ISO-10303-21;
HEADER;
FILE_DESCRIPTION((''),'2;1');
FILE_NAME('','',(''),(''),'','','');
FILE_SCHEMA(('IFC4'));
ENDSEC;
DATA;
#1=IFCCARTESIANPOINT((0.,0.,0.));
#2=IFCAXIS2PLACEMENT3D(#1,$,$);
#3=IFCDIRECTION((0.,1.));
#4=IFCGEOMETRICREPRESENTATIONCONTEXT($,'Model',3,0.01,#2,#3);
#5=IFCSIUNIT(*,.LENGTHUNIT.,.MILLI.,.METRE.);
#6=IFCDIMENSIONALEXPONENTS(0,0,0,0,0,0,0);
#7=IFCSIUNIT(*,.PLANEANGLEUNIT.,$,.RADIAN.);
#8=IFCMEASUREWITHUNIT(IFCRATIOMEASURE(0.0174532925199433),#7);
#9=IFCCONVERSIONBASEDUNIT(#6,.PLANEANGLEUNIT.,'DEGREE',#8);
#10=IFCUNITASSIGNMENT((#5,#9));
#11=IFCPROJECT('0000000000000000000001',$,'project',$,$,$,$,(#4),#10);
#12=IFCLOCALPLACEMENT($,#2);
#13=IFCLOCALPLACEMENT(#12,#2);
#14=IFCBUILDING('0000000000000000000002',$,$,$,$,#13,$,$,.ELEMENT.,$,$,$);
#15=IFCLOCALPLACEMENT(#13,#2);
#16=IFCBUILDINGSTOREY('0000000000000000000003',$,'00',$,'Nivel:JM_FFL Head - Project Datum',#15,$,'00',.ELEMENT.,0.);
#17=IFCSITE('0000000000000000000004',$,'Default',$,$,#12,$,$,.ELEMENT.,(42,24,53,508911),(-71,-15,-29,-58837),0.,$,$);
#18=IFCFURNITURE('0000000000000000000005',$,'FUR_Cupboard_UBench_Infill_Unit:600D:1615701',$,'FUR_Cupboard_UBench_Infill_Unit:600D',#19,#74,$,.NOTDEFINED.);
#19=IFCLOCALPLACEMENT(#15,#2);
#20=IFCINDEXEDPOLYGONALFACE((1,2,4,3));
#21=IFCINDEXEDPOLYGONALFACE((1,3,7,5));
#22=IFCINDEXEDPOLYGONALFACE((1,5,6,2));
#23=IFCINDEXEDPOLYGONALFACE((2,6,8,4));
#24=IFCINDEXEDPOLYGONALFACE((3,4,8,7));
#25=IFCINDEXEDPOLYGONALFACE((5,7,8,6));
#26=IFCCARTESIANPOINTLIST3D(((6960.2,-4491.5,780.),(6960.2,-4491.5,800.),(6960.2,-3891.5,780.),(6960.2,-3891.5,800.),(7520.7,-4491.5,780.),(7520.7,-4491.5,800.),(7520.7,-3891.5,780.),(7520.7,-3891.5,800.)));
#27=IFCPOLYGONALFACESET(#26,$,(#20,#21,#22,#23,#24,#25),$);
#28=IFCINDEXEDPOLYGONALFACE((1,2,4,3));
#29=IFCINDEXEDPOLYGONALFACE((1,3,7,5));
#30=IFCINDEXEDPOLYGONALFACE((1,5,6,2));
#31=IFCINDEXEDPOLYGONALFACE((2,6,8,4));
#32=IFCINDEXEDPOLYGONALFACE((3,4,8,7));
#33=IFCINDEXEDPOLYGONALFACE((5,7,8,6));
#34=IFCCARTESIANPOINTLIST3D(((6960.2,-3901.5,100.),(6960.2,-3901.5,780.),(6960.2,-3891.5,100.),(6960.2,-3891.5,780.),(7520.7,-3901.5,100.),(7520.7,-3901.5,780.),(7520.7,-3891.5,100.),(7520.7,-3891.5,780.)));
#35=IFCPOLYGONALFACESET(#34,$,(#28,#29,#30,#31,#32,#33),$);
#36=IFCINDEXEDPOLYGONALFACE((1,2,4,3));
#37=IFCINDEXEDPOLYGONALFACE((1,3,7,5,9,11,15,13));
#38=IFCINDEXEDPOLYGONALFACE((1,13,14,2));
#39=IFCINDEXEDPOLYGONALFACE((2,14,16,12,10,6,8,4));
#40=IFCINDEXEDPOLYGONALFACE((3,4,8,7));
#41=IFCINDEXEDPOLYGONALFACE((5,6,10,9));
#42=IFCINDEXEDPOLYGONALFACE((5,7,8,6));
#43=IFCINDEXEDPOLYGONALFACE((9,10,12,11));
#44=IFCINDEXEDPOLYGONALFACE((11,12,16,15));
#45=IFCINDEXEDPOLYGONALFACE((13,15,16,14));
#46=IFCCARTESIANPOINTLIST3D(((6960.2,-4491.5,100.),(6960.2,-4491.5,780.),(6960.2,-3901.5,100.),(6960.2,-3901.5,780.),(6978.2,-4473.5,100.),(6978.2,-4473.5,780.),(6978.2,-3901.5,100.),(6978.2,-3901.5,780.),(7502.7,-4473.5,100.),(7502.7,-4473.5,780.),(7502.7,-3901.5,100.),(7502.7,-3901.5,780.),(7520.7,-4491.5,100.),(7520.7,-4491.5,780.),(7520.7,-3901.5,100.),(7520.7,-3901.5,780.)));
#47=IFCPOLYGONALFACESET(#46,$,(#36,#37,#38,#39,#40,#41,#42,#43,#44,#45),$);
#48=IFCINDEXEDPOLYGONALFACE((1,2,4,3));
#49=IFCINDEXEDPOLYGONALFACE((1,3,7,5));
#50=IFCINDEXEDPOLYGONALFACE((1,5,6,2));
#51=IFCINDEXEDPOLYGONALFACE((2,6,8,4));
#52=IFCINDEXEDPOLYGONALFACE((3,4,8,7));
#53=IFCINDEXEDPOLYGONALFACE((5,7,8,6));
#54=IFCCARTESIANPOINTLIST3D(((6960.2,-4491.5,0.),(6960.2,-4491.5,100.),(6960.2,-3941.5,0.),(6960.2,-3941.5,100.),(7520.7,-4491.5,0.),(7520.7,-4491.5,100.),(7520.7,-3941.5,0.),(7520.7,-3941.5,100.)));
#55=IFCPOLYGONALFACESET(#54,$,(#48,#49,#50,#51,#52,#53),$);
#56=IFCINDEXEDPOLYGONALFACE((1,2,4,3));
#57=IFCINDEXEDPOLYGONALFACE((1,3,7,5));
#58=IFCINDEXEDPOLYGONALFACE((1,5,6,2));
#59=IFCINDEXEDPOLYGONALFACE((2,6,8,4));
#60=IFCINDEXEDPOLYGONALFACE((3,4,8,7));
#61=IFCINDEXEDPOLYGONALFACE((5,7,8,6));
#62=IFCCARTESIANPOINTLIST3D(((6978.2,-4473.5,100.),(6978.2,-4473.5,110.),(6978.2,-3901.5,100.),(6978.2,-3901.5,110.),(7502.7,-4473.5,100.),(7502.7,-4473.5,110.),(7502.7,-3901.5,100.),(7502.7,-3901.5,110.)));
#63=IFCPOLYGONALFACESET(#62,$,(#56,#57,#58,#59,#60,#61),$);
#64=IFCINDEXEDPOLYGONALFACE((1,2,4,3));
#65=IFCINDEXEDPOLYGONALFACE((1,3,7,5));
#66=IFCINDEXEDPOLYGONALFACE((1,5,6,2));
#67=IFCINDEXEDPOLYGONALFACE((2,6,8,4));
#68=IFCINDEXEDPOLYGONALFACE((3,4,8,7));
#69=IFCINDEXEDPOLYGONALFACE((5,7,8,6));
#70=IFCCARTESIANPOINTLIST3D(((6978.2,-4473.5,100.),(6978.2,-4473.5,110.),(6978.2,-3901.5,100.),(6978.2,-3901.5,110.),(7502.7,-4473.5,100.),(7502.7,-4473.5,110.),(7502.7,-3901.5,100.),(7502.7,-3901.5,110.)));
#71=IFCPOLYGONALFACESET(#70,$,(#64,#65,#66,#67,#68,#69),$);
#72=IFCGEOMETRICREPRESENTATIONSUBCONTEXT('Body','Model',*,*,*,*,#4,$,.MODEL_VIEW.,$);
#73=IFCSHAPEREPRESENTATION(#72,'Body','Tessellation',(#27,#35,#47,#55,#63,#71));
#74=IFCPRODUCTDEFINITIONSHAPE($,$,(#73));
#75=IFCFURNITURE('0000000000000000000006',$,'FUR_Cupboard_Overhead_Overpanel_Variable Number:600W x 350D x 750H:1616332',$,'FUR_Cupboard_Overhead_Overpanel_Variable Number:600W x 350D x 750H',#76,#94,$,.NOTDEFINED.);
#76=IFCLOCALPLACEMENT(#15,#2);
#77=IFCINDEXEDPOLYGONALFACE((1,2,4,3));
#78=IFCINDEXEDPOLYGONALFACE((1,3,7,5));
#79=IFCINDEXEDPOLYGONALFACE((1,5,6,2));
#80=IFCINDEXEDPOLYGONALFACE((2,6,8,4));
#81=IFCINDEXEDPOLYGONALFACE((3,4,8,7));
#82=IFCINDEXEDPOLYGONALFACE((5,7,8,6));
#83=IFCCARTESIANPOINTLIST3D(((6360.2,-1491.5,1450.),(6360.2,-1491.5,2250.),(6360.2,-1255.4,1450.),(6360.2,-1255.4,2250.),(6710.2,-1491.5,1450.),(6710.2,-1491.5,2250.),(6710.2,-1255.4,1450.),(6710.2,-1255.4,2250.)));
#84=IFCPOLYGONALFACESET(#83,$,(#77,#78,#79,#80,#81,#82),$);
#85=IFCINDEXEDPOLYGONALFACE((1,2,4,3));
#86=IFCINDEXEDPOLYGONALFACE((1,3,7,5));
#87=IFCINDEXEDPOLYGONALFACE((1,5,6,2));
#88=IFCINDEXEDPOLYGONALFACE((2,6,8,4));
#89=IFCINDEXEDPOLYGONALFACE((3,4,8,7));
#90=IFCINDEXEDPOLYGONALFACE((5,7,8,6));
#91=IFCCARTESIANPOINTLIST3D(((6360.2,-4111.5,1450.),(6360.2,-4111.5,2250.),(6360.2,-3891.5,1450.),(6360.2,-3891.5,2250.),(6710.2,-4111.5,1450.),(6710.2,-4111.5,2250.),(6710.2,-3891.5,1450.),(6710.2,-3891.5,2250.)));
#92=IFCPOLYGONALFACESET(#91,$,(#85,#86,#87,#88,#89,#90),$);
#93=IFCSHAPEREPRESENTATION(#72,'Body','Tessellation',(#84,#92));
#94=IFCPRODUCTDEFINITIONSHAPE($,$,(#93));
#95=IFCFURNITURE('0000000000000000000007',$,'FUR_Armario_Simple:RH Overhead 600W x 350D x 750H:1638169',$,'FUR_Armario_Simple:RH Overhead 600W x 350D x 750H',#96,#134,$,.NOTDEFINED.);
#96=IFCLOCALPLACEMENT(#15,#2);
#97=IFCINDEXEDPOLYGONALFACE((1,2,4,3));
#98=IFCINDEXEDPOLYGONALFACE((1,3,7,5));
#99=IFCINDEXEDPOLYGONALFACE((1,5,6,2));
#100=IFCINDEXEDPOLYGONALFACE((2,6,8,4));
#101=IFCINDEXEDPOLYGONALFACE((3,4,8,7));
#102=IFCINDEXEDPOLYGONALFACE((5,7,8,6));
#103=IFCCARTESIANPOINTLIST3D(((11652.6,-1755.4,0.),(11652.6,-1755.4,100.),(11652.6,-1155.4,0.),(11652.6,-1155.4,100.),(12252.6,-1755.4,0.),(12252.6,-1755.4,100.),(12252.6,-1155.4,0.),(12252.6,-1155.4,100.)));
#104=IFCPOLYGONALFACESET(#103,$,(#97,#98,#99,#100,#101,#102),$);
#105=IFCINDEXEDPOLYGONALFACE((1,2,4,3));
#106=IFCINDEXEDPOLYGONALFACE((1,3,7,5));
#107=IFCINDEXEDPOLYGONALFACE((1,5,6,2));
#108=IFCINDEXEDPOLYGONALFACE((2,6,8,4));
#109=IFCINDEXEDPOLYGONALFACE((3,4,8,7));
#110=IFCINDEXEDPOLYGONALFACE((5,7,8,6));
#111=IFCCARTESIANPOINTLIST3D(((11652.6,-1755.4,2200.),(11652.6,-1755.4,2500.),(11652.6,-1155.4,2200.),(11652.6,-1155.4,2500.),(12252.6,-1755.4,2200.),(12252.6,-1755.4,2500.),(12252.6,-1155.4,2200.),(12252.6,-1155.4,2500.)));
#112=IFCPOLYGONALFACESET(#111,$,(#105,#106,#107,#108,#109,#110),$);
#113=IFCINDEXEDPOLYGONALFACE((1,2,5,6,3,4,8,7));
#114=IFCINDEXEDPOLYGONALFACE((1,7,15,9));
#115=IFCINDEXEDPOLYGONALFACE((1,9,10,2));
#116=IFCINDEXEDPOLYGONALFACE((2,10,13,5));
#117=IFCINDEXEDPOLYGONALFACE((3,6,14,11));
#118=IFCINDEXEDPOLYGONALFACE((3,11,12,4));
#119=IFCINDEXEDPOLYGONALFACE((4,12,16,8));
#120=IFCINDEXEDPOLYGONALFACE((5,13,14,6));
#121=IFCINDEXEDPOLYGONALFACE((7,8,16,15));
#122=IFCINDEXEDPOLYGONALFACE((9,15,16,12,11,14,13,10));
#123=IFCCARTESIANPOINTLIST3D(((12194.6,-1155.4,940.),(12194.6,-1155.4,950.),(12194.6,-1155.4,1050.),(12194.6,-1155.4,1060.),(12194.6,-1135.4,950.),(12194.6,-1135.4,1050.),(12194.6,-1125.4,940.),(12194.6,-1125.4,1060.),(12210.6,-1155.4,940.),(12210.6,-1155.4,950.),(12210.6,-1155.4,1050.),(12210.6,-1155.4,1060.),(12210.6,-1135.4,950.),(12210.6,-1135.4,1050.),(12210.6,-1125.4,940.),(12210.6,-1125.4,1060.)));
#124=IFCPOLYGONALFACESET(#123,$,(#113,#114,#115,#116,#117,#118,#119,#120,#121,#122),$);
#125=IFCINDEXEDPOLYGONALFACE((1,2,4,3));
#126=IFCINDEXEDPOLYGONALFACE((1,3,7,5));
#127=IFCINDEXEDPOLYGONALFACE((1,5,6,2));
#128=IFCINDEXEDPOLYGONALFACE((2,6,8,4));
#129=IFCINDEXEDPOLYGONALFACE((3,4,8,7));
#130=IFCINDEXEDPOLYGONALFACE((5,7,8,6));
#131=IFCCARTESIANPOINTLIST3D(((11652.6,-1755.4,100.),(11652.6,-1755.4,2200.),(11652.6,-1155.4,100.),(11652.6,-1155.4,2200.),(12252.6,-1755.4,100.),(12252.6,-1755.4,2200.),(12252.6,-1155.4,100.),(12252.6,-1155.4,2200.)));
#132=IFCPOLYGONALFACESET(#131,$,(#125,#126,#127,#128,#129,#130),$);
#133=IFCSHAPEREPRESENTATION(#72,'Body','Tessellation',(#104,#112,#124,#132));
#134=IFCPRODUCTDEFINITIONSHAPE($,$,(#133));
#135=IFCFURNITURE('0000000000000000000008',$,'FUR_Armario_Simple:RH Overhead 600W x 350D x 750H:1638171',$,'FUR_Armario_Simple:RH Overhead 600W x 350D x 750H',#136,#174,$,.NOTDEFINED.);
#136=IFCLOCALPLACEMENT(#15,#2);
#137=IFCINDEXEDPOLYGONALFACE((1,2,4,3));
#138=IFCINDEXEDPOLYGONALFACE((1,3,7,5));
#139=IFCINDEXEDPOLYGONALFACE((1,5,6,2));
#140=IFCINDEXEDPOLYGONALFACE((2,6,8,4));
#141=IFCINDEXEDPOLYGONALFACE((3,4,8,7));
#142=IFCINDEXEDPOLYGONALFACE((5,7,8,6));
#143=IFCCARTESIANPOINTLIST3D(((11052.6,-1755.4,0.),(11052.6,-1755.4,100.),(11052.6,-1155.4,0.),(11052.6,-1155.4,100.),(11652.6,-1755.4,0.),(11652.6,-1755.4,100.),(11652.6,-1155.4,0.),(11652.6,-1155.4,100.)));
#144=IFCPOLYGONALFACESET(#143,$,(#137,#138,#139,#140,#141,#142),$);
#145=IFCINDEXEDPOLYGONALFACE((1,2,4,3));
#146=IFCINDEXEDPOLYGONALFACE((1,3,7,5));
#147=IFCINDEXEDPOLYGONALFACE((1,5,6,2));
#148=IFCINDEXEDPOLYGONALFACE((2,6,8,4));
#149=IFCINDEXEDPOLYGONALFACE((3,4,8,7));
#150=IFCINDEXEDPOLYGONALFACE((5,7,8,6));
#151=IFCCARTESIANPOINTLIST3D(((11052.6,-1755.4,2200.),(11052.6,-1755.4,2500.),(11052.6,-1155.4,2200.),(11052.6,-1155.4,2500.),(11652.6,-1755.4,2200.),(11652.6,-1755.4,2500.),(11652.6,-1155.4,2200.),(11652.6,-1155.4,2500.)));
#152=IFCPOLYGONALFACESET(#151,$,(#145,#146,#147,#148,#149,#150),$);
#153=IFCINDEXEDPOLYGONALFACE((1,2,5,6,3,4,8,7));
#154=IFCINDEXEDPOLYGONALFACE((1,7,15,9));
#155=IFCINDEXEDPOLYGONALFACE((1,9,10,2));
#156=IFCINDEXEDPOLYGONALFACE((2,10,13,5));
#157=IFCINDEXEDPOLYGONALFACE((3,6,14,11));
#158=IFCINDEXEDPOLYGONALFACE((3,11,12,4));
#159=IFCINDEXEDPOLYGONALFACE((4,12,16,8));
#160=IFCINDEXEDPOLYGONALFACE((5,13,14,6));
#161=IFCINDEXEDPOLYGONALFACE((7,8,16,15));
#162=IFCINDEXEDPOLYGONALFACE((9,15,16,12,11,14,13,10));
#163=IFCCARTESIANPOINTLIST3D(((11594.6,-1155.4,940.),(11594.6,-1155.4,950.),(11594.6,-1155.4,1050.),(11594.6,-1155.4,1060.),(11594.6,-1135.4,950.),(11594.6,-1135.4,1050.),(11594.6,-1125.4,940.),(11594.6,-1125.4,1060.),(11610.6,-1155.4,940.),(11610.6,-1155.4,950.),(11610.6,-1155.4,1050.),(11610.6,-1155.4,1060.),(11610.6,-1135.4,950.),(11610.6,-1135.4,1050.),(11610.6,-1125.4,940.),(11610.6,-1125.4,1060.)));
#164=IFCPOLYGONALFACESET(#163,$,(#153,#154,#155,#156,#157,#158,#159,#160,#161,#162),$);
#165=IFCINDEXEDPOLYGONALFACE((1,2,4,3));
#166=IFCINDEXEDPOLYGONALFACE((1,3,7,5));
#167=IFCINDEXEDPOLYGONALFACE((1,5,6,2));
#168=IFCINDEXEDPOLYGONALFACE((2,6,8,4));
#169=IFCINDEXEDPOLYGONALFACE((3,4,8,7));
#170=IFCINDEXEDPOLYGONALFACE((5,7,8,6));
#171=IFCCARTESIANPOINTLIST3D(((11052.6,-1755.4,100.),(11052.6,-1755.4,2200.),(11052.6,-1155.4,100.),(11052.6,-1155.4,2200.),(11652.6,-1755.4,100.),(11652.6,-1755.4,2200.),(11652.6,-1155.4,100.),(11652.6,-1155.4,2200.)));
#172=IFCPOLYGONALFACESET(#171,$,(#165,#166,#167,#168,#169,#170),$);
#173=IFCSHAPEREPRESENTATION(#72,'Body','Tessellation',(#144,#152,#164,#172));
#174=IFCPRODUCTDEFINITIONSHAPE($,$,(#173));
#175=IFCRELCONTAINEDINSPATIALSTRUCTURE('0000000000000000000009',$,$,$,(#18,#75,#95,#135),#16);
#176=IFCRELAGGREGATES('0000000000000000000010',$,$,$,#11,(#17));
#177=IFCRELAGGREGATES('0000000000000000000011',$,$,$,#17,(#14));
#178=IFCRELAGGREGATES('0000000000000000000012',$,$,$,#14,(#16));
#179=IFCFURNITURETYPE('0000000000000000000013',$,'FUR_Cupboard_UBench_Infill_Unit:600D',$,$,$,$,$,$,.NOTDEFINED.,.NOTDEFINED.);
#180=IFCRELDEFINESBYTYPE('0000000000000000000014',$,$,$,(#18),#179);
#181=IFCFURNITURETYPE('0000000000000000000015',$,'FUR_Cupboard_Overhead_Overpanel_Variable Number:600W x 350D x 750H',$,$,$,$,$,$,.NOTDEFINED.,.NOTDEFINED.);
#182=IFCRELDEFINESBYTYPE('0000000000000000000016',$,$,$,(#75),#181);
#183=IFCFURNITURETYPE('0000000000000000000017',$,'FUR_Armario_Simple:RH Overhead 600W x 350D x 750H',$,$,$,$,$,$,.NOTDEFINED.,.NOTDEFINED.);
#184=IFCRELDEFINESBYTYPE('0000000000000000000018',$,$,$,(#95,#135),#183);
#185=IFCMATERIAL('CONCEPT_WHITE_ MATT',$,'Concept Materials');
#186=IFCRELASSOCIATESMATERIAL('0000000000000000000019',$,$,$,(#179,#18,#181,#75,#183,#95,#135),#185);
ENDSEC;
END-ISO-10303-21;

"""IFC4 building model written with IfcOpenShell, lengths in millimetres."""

from ifc_helpers import new_model, entity, si_unit, converted_unit, direction, frame, origin, place, context, subcontext, project, spatial, indexed_curve, outline, extrude, source, transform, mapped, material, type_object, type_shapes, element, save


model = new_model("IFC4")

# Units and contexts
model_context = context("Model", 3, precision=0.01, world=origin(), true_north=direction((0.0, 1.0)))
body_context = subcontext(model_context, "Body", "Model", "MODEL_VIEW")
ifc_project = project(units=[si_unit("LENGTHUNIT", "METRE", prefix="MILLI"), converted_unit("PLANEANGLEUNIT", "DEGREE", entity("IfcRatioMeasure", 0.0174532925199433), si_unit("PLANEANGLEUNIT", "RADIAN"), dimensions=[0, 0, 0, 0, 0, 0, 0])], contexts=[model_context])

# Site, building, storey
site_placement = place(None, origin())
site = spatial("IfcSite", under=ifc_project, at=site_placement, Name="Default", CompositionType="ELEMENT", RefLatitude=(42, 24, 53, 508911), RefLongitude=(-71, -15, -29, -58837), RefElevation=0.0)
building_placement = place(site_placement, origin())
building = spatial("IfcBuilding", under=site, at=building_placement, CompositionType="ELEMENT")
storey_placement = place(building_placement, origin())
storey = spatial("IfcBuildingStorey", under=building, at=storey_placement, Name="00", ObjectType="Nivel:JM_FFL Head - Project Datum", LongName="00", CompositionType="ELEMENT", Elevation=0.0)

# Furniture
ifc_material_1 = material(Name="CONCEPT_WHITE_ MATT", Category="Concept Materials")
furniture_type_1 = type_object("IfcFurnitureType", Name="FUR_Cupboard_UBench_Infill_Unit:600D", AssemblyPlace="NOTDEFINED", PredefinedType="NOTDEFINED", material=ifc_material_1)
shared_shape_1 = source(origin(), body_context, "Body", "SweptSolid", [
    extrude(outline(indexed_curve([(-300.0, -280.3), (300.0, -280.3), (300.0, 280.3), (-300.0, 280.3), (-300.0, -280.3)], self_intersect=False)), frame((44.7, 300.0, 780.0), z_axis=(0.0, 0.0, 1.0), x_axis=(0.0, 1.0, 0.0)), (0.0, 0.0, 1.0), 20.0),
    extrude(outline(indexed_curve([(-5.0, -280.3), (5.0, -280.3), (5.0, 280.3), (-5.0, 280.3), (-5.0, -280.3)], self_intersect=False)), frame((44.7, 595.0, 100.0), z_axis=(0.0, 0.0, 1.0), x_axis=(0.0, 1.0, 0.0)), (0.0, 0.0, 1.0), 680.0),
    extrude(outline(indexed_curve([(-299.5, -280.3), (290.5, -280.3), (290.5, -262.3), (-281.5, -262.3), (-281.5, 262.3), (290.5, 262.3), (290.5, 280.3), (-299.5, 280.3), (-299.5, -280.3)], self_intersect=False)), frame((44.7, 299.5, 100.0), z_axis=(0.0, 0.0, 1.0), x_axis=(0.0, 1.0, 0.0)), (0.0, 0.0, 1.0), 680.0),
    extrude(outline(indexed_curve([(-275.0, -280.3), (275.0, -280.3), (275.0, 280.3), (-275.0, 280.3), (-275.0, -280.3)], self_intersect=False)), frame((44.7, 275.0, 0.0), z_axis=(0.0, 0.0, 1.0), x_axis=(0.0, 1.0, 0.0)), (0.0, 0.0, 1.0), 100.0),
    extrude(outline(indexed_curve([(-286.0, -262.3), (286.0, -262.3), (286.0, 262.3), (-286.0, 262.3), (-286.0, -262.3)], self_intersect=False)), frame((44.7, 304.0, 100.0), z_axis=(0.0, 0.0, 1.0), x_axis=(0.0, 1.0, 0.0)), (0.0, 0.0, 1.0), 10.0),
    extrude(outline(indexed_curve([(-286.0, -262.3), (286.0, -262.3), (286.0, 262.3), (-286.0, 262.3), (-286.0, -262.3)], self_intersect=False)), frame((44.7, 304.0, 100.0), z_axis=(0.0, 0.0, 1.0), x_axis=(0.0, 1.0, 0.0)), (0.0, 0.0, 1.0), 10.0),
])
type_shapes(furniture_type_1, [shared_shape_1])
furniture_1_placement = place(storey_placement, frame((7195.7, -4491.5, 0.0)))
element("IfcFurniture", 1, at=furniture_1_placement, inside=storey, type_object=furniture_type_1, material=ifc_material_1, Name="FUR_Cupboard_UBench_Infill_Unit:600D:1615701", ObjectType="FUR_Cupboard_UBench_Infill_Unit:600D", PredefinedType="NOTDEFINED", context=body_context, shape_type="MappedRepresentation", body=[
    mapped(shared_shape_1, transform((0.0, 0.0, 0.0), scale=1.0)),
])
furniture_type_2 = type_object("IfcFurnitureType", Name="FUR_Cupboard_Overhead_Overpanel_Variable Number:600W x 350D x 750H", AssemblyPlace="NOTDEFINED", PredefinedType="NOTDEFINED", material=ifc_material_1)
shared_shape_2 = source(origin(), body_context, "Body", "SweptSolid", [
    extrude(outline(indexed_curve([(-175.0, -118.0), (175.0, -118.0), (175.0, 118.0), (-175.0, 118.0), (-175.0, -118.0)], self_intersect=False)), frame((2518.0, -175.0, 1500.0), z_axis=(0.0, 0.0, 1.0), x_axis=(0.0, -1.0, 0.0)), (0.0, 0.0, 1.0), 800.0),
    extrude(outline(indexed_curve([(-110.0, -175.0), (110.0, -175.0), (110.0, 175.0), (-110.0, 175.0), (-110.0, -175.0)], self_intersect=False)), frame((-110.0, -175.0, 1500.0), z_axis=(0.0, 0.0, 1.0), x_axis=(-1.0, 0.0, 0.0)), (0.0, 0.0, 1.0), 800.0),
])
type_shapes(furniture_type_2, [shared_shape_2])
furniture_2_placement = place(storey_placement, frame((6360.2, -3891.5, -50.0), z_axis=(0.0, 0.0, 1.0), x_axis=(0.0, 1.0, 0.0)))
element("IfcFurniture", 2, at=furniture_2_placement, inside=storey, type_object=furniture_type_2, material=ifc_material_1, Name="FUR_Cupboard_Overhead_Overpanel_Variable Number:600W x 350D x 750H:1616332", ObjectType="FUR_Cupboard_Overhead_Overpanel_Variable Number:600W x 350D x 750H", PredefinedType="NOTDEFINED", context=body_context, shape_type="MappedRepresentation", body=[
    mapped(shared_shape_2, transform((0.0, 0.0, 0.0), scale=1.0)),
])
furniture_type_3 = type_object("IfcFurnitureType", Name="FUR_Armario_Simple:RH Overhead 600W x 350D x 750H", AssemblyPlace="NOTDEFINED", PredefinedType="NOTDEFINED", material=ifc_material_1)
shared_shape_3 = source(origin(), body_context, "Body", "SweptSolid", [
    extrude(outline(indexed_curve([(-300.0, -300.0), (300.0, -300.0), (300.0, 300.0), (-300.0, 300.0), (-300.0, -300.0)], self_intersect=False)), frame((300.0, 300.0, 0.0), z_axis=(0.0, 0.0, 1.0), x_axis=(0.0, 1.0, 0.0)), (0.0, 0.0, 1.0), 100.0),
    extrude(outline(indexed_curve([(-300.0, -300.0), (300.0, -300.0), (300.0, 300.0), (-300.0, 300.0), (-300.0, -300.0)], self_intersect=False)), frame((300.0, 300.0, 2200.0), z_axis=(0.0, 0.0, 1.0), x_axis=(0.0, 1.0, 0.0)), (0.0, 0.0, 1.0), 300.0),
    extrude(outline(indexed_curve([(-17.5, -60.0), (12.5, -60.0), (12.5, -50.0), (-7.5, -50.0), (-7.5, 50.0), (12.5, 50.0), (12.5, 60.0), (-17.5, 60.0), (-17.5, -60.0)], self_intersect=False)), frame((542.0, 612.5, 1000.0), z_axis=(1.0, 0.0, 0.0), x_axis=(0.0, -1.0, 0.0)), (0.0, 0.0, 1.0), 16.0),
    extrude(outline(indexed_curve([(-300.0, -300.0), (300.0, -300.0), (300.0, 300.0), (-300.0, 300.0), (-300.0, -300.0)], self_intersect=False)), frame((300.0, 300.0, 100.0), z_axis=(0.0, 0.0, 1.0), x_axis=(-1.0, 0.0, 0.0)), (0.0, 0.0, 1.0), 2100.0),
])
type_shapes(furniture_type_3, [shared_shape_3])
for number, where, name in (
    (3, (11652.6, -1755.4, 0.0), "FUR_Armario_Simple:RH Overhead 600W x 350D x 750H:1638169"),
    (4, (11052.6, -1755.4, 0.0), "FUR_Armario_Simple:RH Overhead 600W x 350D x 750H:1638171"),
):
    element("IfcFurniture", number, at=place(storey_placement, frame(where)), inside=storey, type_object=furniture_type_3, material=ifc_material_1, Name=name, ObjectType="FUR_Armario_Simple:RH Overhead 600W x 350D x 750H", PredefinedType="NOTDEFINED", context=body_context, shape_type="MappedRepresentation", body=[
        mapped(shared_shape_3, transform((0.0, 0.0, 0.0), scale=1.0)),
    ])

save(model, "model.ifc")
